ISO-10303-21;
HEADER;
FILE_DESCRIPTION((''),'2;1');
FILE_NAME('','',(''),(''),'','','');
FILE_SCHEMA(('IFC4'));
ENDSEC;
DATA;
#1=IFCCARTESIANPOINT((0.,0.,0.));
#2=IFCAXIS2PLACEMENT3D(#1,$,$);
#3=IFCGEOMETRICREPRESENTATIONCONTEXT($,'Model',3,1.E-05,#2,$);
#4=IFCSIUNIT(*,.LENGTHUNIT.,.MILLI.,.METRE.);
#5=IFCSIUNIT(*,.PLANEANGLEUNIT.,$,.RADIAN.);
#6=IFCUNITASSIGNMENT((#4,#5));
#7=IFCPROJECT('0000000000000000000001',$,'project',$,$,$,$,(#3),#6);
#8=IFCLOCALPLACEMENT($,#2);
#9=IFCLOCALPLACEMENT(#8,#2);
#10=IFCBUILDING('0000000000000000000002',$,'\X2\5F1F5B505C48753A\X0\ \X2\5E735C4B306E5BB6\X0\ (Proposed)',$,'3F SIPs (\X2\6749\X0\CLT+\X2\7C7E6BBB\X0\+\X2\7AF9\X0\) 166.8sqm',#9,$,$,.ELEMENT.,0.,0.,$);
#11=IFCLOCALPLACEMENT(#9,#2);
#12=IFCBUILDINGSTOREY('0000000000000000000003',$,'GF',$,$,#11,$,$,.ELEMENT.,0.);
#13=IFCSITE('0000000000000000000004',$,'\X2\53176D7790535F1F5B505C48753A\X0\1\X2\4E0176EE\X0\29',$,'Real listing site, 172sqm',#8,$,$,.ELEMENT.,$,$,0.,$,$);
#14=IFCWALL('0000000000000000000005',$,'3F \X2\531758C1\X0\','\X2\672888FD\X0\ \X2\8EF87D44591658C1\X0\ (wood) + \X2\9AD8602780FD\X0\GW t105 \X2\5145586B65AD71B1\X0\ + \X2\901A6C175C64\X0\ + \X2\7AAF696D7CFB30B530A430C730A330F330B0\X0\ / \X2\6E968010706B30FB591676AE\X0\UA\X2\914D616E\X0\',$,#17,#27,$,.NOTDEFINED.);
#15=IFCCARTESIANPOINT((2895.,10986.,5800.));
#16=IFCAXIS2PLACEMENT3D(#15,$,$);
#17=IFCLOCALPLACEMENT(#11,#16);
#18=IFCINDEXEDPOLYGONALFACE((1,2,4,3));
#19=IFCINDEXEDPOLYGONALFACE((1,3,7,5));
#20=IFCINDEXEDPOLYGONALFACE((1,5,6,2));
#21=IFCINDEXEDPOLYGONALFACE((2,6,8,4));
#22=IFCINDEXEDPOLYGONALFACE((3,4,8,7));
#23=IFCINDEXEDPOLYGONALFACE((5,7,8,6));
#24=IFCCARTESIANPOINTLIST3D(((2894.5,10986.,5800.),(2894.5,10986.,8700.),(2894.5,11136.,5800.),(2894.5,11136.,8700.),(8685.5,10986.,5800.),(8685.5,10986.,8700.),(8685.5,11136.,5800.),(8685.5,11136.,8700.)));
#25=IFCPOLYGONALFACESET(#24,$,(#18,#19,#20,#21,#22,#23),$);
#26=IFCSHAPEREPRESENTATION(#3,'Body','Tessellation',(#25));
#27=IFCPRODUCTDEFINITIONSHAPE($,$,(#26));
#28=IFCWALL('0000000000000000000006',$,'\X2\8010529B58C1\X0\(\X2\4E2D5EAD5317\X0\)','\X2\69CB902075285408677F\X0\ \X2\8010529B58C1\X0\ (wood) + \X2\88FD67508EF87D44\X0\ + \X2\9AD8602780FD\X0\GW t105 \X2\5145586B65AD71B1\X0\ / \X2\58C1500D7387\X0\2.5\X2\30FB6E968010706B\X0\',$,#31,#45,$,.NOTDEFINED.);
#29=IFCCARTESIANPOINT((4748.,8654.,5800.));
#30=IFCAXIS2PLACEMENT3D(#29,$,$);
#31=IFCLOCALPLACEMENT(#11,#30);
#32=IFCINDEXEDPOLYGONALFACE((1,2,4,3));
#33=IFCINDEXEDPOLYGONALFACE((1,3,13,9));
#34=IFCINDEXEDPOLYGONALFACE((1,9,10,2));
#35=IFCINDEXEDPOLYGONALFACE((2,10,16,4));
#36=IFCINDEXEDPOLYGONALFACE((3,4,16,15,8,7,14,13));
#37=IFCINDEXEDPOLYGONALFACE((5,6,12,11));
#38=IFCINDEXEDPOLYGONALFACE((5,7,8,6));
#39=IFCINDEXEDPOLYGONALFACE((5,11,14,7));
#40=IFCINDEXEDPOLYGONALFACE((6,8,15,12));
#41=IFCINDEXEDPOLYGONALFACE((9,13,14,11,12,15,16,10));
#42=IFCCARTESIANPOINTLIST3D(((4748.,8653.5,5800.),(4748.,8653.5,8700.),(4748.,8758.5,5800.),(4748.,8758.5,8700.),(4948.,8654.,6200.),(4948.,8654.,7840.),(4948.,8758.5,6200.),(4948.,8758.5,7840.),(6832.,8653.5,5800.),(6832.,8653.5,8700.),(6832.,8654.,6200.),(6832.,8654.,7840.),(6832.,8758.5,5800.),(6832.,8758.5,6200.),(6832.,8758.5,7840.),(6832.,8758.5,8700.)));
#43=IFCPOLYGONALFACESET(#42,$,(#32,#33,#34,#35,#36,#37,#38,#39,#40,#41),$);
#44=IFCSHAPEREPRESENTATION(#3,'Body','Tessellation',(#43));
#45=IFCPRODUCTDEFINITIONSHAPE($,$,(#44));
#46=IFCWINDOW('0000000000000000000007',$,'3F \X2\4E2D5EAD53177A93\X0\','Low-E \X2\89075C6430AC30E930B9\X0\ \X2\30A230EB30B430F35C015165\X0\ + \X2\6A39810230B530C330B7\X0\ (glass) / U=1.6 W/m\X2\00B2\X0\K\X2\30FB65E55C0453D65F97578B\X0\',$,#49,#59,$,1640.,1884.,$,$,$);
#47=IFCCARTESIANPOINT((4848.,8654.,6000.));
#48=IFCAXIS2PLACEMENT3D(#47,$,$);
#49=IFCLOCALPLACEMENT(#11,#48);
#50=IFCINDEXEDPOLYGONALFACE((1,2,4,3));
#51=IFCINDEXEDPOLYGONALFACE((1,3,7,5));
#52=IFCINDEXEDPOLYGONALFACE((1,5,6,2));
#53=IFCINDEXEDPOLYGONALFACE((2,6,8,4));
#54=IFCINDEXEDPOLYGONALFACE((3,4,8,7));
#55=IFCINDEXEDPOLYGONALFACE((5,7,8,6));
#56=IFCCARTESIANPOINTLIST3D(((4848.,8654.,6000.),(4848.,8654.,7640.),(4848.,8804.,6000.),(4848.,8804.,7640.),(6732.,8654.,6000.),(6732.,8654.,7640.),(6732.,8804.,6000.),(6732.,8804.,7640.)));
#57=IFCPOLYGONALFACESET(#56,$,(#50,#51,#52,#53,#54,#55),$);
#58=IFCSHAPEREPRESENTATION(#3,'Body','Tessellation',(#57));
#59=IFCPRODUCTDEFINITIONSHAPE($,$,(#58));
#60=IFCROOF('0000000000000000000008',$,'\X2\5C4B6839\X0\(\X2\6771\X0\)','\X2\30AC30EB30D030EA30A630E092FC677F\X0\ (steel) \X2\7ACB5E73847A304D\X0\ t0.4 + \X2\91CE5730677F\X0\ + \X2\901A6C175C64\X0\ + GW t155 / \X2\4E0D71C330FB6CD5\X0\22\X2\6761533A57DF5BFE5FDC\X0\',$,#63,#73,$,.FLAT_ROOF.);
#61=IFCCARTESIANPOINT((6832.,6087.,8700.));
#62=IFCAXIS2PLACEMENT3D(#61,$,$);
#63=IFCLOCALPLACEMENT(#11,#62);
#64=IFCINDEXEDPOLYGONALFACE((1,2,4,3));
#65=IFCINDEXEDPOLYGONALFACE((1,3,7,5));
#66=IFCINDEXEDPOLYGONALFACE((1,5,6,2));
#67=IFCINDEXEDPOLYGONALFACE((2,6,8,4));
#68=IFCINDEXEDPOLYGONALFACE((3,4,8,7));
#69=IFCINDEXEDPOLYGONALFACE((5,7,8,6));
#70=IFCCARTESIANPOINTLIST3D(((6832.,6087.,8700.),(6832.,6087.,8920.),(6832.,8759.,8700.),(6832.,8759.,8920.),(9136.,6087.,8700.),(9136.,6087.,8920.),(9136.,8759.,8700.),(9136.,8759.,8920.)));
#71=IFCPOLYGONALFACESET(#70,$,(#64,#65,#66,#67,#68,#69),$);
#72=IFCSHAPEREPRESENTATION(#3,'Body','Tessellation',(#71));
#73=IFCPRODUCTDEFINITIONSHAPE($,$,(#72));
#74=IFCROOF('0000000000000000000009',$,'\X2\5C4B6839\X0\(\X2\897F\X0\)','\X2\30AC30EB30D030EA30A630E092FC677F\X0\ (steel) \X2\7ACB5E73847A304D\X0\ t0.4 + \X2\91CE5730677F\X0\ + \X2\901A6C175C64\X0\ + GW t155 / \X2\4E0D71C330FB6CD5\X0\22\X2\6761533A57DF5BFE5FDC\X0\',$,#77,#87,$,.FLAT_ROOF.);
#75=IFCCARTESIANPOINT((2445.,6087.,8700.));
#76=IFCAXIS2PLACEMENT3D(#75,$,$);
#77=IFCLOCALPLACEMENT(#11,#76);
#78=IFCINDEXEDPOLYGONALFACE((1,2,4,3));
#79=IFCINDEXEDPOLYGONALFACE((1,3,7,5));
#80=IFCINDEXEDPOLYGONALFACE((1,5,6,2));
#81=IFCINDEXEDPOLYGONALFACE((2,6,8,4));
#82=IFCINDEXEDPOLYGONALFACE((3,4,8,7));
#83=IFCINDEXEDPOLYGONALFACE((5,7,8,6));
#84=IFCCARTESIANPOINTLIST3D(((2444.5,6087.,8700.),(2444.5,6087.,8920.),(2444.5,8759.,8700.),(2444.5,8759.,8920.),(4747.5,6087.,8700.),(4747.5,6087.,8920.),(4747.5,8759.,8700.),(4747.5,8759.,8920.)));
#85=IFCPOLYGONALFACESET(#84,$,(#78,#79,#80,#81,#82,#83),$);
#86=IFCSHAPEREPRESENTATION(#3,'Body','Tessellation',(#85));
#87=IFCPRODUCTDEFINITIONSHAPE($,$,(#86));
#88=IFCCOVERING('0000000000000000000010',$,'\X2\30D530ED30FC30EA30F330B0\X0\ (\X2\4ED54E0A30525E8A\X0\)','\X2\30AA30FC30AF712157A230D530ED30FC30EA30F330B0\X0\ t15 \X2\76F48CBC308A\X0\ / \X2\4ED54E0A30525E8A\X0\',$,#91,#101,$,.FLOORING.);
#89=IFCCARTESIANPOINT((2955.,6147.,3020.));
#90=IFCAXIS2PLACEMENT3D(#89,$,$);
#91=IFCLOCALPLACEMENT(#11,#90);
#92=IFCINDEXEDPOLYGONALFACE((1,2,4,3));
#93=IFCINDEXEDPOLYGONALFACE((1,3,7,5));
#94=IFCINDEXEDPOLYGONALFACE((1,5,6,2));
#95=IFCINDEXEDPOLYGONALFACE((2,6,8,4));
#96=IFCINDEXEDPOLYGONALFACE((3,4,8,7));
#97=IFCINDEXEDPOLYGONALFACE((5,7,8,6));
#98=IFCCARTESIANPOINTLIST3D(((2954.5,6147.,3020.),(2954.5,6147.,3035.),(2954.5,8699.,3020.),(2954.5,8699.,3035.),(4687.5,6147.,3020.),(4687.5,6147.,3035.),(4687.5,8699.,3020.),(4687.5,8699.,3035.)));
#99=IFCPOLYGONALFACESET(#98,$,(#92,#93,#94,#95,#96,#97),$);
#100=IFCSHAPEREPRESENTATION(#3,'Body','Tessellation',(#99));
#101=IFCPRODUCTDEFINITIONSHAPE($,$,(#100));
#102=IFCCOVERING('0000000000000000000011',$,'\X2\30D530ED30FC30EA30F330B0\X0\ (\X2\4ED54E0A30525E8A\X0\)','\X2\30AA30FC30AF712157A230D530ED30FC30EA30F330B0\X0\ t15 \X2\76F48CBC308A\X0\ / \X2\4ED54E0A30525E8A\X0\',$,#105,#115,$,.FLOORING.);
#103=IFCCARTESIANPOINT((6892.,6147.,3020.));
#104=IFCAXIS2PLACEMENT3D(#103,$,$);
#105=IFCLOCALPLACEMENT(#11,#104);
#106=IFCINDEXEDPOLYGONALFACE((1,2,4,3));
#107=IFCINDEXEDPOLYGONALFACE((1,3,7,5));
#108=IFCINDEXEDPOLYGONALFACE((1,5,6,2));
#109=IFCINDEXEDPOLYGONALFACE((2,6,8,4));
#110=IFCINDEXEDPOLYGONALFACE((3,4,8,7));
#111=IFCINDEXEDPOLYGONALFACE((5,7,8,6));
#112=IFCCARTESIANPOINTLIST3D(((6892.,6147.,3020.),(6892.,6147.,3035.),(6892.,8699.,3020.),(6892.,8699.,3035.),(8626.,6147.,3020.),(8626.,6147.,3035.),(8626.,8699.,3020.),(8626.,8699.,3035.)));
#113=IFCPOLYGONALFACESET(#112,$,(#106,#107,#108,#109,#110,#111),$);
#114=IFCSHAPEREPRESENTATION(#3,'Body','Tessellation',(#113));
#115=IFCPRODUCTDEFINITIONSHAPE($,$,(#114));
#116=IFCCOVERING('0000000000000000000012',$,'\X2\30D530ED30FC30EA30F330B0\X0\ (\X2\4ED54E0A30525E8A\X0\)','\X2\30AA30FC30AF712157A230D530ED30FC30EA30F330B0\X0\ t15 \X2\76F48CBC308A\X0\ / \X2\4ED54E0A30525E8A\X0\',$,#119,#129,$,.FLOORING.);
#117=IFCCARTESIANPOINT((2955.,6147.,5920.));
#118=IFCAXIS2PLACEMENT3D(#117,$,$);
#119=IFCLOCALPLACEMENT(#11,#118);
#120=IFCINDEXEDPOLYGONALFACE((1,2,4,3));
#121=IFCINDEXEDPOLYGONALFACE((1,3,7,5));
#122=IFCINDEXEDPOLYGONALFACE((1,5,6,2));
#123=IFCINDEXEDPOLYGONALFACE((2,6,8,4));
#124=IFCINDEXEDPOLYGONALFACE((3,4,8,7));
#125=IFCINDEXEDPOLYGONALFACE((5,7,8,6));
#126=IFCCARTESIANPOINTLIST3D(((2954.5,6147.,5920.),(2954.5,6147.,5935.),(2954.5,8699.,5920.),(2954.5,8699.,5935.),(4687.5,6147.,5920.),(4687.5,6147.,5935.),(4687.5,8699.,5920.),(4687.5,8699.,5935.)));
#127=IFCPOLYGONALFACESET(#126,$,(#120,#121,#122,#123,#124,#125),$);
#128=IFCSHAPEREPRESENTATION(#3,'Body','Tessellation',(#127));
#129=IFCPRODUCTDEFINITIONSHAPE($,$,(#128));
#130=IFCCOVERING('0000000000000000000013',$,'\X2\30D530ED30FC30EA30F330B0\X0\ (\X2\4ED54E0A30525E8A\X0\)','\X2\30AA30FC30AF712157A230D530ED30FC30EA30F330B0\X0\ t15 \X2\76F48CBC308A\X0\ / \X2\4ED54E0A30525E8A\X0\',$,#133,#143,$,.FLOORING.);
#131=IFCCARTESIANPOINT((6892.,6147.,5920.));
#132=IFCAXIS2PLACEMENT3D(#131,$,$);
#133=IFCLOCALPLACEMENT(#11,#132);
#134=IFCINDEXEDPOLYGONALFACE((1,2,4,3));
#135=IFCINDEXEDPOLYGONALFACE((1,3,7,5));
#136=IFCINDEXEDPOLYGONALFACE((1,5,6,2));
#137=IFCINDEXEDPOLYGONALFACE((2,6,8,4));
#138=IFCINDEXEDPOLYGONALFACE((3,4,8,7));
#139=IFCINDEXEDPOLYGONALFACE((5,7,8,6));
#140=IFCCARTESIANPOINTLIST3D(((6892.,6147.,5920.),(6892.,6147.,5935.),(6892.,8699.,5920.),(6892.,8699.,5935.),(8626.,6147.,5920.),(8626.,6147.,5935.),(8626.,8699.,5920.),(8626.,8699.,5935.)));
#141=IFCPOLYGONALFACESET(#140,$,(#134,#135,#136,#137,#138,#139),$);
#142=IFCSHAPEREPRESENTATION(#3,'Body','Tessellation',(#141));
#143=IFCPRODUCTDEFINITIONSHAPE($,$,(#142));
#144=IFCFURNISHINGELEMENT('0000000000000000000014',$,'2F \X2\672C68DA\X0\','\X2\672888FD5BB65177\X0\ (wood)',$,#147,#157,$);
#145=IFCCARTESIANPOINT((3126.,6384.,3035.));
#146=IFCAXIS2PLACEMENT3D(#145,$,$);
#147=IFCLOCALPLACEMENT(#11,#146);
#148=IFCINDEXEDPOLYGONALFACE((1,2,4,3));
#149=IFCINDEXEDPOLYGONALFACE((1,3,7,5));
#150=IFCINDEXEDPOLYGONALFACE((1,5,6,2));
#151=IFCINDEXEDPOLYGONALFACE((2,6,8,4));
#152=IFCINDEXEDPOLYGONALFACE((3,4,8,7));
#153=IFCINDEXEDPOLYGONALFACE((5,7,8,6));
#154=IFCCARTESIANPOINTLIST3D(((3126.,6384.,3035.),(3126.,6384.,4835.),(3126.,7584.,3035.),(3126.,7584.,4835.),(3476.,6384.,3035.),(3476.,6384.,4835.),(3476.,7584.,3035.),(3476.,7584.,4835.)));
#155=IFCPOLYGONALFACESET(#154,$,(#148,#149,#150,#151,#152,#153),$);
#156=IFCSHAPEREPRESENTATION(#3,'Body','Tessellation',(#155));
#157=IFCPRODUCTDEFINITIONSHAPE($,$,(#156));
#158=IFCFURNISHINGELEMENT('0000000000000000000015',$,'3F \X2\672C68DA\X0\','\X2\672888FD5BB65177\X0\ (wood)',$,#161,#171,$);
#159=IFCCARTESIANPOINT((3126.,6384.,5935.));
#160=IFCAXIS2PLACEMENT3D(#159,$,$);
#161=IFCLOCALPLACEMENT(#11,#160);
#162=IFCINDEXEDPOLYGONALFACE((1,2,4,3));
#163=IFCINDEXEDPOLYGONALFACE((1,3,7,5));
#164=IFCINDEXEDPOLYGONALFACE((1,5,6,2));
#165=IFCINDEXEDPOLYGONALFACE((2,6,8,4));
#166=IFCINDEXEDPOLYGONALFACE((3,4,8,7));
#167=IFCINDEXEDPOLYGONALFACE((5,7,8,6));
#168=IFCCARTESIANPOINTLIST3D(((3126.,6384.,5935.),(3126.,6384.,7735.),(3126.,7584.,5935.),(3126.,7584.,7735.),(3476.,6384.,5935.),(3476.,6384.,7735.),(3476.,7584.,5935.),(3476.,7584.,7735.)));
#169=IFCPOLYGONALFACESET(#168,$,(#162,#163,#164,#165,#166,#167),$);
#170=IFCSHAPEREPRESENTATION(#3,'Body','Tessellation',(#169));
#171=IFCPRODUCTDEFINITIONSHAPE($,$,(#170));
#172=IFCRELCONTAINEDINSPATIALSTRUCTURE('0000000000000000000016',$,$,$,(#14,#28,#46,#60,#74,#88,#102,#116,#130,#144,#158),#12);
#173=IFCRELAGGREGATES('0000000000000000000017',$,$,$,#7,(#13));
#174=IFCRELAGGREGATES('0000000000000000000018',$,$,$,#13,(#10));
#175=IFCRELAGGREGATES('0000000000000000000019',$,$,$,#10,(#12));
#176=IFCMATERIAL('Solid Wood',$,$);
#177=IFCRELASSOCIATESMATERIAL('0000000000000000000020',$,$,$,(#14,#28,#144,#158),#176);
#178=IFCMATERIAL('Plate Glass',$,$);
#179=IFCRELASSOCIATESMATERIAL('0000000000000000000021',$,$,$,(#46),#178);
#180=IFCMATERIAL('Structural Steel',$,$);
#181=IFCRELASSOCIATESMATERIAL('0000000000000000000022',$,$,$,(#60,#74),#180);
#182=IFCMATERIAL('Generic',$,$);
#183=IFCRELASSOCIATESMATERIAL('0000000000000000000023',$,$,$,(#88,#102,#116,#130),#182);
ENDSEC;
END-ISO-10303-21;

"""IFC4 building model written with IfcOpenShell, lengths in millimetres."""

from ifc_helpers import new_model, si_unit, frame, frame_2d, origin, place, context, project, spatial, rectangle, extrude, material, element, fill, save


model = new_model("IFC4")

# Units and contexts
model_context = context("Model", 3, precision=1e-05, world=origin())
ifc_project = project(units=[si_unit("LENGTHUNIT", "METRE", prefix="MILLI"), si_unit("PLANEANGLEUNIT", "RADIAN")], contexts=[model_context])

# Site, building, storey
site_placement = place(None, origin())
site = spatial("IfcSite", under=ifc_project, at=site_placement, Name="北海道弟子屈町1丁目29", ObjectType="Real listing site, 172sqm", CompositionType="ELEMENT", RefElevation=0.0)
building_placement = place(site_placement, origin())
building = spatial("IfcBuilding", under=site, at=building_placement, Name="弟子屈町 平屋の家 (Proposed)", ObjectType="3F SIPs (杉CLT+籾殻+竹) 166.8sqm", CompositionType="ELEMENT", ElevationOfRefHeight=0.0, ElevationOfTerrain=0.0)
storey_placement = place(building_placement, origin())
storey = spatial("IfcBuildingStorey", under=building, at=storey_placement, Name="GF", CompositionType="ELEMENT", Elevation=0.0)

# Shared definitions
ifc_material_1 = material(Name="Solid Wood")

# Wall
wall_1_placement = place(storey_placement, frame((2895.0, 10986.0, 5800.0)))
element("IfcWall", 1, at=wall_1_placement, inside=storey, material=ifc_material_1, Name="3F 北壁", Description="木製 軸組外壁 (wood) + 高性能GW t105 充填断熱 + 通気層 + 窯業系サイディング / 準耐火・外皮UA配慮", PredefinedType="NOTDEFINED", context=model_context, shape_type="SweptSolid", body=[
    extrude(rectangle(XDim=5791.0, YDim=150.0, at=frame_2d((2895.0, 75.0))), frame((2895.0, 10986.0, 5800.0)), (0.0, 0.0, 1.0), 2900.0),
])

# Wall, opening, window
wall_2_placement = place(storey_placement, frame((4748.0, 8654.0, 5800.0)))
wall_2 = element("IfcWall", 2, at=wall_2_placement, inside=storey, material=ifc_material_1, Name="耐力壁(中庭北)", Description="構造用合板 耐力壁 (wood) + 製材軸組 + 高性能GW t105 充填断熱 / 壁倍率2.5・準耐火", PredefinedType="NOTDEFINED", context=model_context, shape_type="SweptSolid", body=[
    extrude(rectangle(XDim=2084.0, YDim=105.0, at=frame_2d((1042.0, 52.0))), frame((4748.0, 8654.0, 5800.0)), (0.0, 0.0, 1.0), 2900.0),
])
opening_placement = place(storey_placement, frame((4848.0, 8654.0, 6000.0)))
opening = element("IfcOpeningElement", 3, at=opening_placement, cuts=wall_2, PredefinedType="NOTDEFINED", context=model_context, shape_type="SweptSolid", body=[
    extrude(rectangle(XDim=1884.0, YDim=150.0, at=frame_2d((942.0, 75.0))), frame((4848.0, 8654.0, 6000.0)), (0.0, 0.0, 1.0), 1640.0),
])
ifc_material_2 = material(Name="Plate Glass")
window_1_placement = place(storey_placement, frame((4848.0, 8654.0, 6000.0)))
window_1 = element("IfcWindow", 4, at=window_1_placement, inside=storey, material=ifc_material_2, Name="3F 中庭北窓", Description="Low-E 複層ガラス アルゴン封入 + 樹脂サッシ (glass) / U=1.6 W/m²K・日射取得型", OverallHeight=1640.0, OverallWidth=1884.0, context=model_context, shape_type="SweptSolid", body=[
    extrude(rectangle(XDim=1884.0, YDim=150.0, at=frame_2d((942.0, 75.0))), frame((4848.0, 8654.0, 6000.0)), (0.0, 0.0, 1.0), 1640.0),
])
fill(opening, window_1)

# Shared definitions
ifc_material_3 = material(Name="Generic")

# Roofs
ifc_material_4 = material(Name="Structural Steel")
roof_1_placement = place(storey_placement, frame((6832.0, 6087.0, 8700.0)))
element("IfcRoof", 5, at=roof_1_placement, inside=storey, material=ifc_material_4, Name="屋根(東)", Description="ガルバリウム鋼板 (steel) 立平葺き t0.4 + 野地板 + 通気層 + GW t155 / 不燃・法22条区域対応", PredefinedType="FLAT_ROOF", context=model_context, shape_type="SweptSolid", body=[
    extrude(rectangle(XDim=2304.0, YDim=2672.0, at=frame_2d((1152.0, 1336.0))), frame((6832.0, 6087.0, 8700.0)), (0.0, 0.0, 1.0), 220.0),
])
roof_2_placement = place(storey_placement, frame((2445.0, 6087.0, 8700.0)))
element("IfcRoof", 6, at=roof_2_placement, inside=storey, material=ifc_material_4, Name="屋根(西)", Description="ガルバリウム鋼板 (steel) 立平葺き t0.4 + 野地板 + 通気層 + GW t155 / 不燃・法22条区域対応", PredefinedType="FLAT_ROOF", context=model_context, shape_type="SweptSolid", body=[
    extrude(rectangle(XDim=2303.0, YDim=2672.0, at=frame_2d((1151.0, 1336.0))), frame((2445.0, 6087.0, 8700.0)), (0.0, 0.0, 1.0), 220.0),
])

# Coverings
covering_1_placement = place(storey_placement, frame((2955.0, 6147.0, 3020.0)))
element("IfcCovering", 7, at=covering_1_placement, inside=storey, material=ifc_material_3, Name="フローリング (仕上げ床)", Description="オーク無垢フローリング t15 直貼り / 仕上げ床", PredefinedType="FLOORING", context=model_context, shape_type="SweptSolid", body=[
    extrude(rectangle(XDim=1733.0, YDim=2552.0, at=frame_2d((866.0, 1276.0))), frame((2955.0, 6147.0, 3020.0)), (0.0, 0.0, 1.0), 15.0),
])
covering_2_placement = place(storey_placement, frame((6892.0, 6147.0, 3020.0)))
element("IfcCovering", 8, at=covering_2_placement, inside=storey, material=ifc_material_3, Name="フローリング (仕上げ床)", Description="オーク無垢フローリング t15 直貼り / 仕上げ床", PredefinedType="FLOORING", context=model_context, shape_type="SweptSolid", body=[
    extrude(rectangle(XDim=1734.0, YDim=2552.0, at=frame_2d((867.0, 1276.0))), frame((6892.0, 6147.0, 3020.0)), (0.0, 0.0, 1.0), 15.0),
])
covering_3_placement = place(storey_placement, frame((2955.0, 6147.0, 5920.0)))
element("IfcCovering", 9, at=covering_3_placement, inside=storey, material=ifc_material_3, Name="フローリング (仕上げ床)", Description="オーク無垢フローリング t15 直貼り / 仕上げ床", PredefinedType="FLOORING", context=model_context, shape_type="SweptSolid", body=[
    extrude(rectangle(XDim=1733.0, YDim=2552.0, at=frame_2d((866.0, 1276.0))), frame((2955.0, 6147.0, 5920.0)), (0.0, 0.0, 1.0), 15.0),
])
covering_4_placement = place(storey_placement, frame((6892.0, 6147.0, 5920.0)))
element("IfcCovering", 10, at=covering_4_placement, inside=storey, material=ifc_material_3, Name="フローリング (仕上げ床)", Description="オーク無垢フローリング t15 直貼り / 仕上げ床", PredefinedType="FLOORING", context=model_context, shape_type="SweptSolid", body=[
    extrude(rectangle(XDim=1734.0, YDim=2552.0, at=frame_2d((867.0, 1276.0))), frame((6892.0, 6147.0, 5920.0)), (0.0, 0.0, 1.0), 15.0),
])

# Furnishing elements
furnishing_1_placement = place(storey_placement, frame((3126.0, 6384.0, 3035.0)))
element("IfcFurnishingElement", 11, at=furnishing_1_placement, inside=storey, material=ifc_material_1, Name="2F 本棚", Description="木製家具 (wood)", context=model_context, shape_type="SweptSolid", body=[
    extrude(rectangle(XDim=350.0, YDim=1200.0, at=frame_2d((175.0, 600.0))), frame((3126.0, 6384.0, 3035.0)), (0.0, 0.0, 1.0), 1800.0),
])
furnishing_2_placement = place(storey_placement, frame((3126.0, 6384.0, 5935.0)))
element("IfcFurnishingElement", 12, at=furnishing_2_placement, inside=storey, material=ifc_material_1, Name="3F 本棚", Description="木製家具 (wood)", context=model_context, shape_type="SweptSolid", body=[
    extrude(rectangle(XDim=350.0, YDim=1200.0, at=frame_2d((175.0, 600.0))), frame((3126.0, 6384.0, 5935.0)), (0.0, 0.0, 1.0), 1800.0),
])

save(model, "model.ifc")
